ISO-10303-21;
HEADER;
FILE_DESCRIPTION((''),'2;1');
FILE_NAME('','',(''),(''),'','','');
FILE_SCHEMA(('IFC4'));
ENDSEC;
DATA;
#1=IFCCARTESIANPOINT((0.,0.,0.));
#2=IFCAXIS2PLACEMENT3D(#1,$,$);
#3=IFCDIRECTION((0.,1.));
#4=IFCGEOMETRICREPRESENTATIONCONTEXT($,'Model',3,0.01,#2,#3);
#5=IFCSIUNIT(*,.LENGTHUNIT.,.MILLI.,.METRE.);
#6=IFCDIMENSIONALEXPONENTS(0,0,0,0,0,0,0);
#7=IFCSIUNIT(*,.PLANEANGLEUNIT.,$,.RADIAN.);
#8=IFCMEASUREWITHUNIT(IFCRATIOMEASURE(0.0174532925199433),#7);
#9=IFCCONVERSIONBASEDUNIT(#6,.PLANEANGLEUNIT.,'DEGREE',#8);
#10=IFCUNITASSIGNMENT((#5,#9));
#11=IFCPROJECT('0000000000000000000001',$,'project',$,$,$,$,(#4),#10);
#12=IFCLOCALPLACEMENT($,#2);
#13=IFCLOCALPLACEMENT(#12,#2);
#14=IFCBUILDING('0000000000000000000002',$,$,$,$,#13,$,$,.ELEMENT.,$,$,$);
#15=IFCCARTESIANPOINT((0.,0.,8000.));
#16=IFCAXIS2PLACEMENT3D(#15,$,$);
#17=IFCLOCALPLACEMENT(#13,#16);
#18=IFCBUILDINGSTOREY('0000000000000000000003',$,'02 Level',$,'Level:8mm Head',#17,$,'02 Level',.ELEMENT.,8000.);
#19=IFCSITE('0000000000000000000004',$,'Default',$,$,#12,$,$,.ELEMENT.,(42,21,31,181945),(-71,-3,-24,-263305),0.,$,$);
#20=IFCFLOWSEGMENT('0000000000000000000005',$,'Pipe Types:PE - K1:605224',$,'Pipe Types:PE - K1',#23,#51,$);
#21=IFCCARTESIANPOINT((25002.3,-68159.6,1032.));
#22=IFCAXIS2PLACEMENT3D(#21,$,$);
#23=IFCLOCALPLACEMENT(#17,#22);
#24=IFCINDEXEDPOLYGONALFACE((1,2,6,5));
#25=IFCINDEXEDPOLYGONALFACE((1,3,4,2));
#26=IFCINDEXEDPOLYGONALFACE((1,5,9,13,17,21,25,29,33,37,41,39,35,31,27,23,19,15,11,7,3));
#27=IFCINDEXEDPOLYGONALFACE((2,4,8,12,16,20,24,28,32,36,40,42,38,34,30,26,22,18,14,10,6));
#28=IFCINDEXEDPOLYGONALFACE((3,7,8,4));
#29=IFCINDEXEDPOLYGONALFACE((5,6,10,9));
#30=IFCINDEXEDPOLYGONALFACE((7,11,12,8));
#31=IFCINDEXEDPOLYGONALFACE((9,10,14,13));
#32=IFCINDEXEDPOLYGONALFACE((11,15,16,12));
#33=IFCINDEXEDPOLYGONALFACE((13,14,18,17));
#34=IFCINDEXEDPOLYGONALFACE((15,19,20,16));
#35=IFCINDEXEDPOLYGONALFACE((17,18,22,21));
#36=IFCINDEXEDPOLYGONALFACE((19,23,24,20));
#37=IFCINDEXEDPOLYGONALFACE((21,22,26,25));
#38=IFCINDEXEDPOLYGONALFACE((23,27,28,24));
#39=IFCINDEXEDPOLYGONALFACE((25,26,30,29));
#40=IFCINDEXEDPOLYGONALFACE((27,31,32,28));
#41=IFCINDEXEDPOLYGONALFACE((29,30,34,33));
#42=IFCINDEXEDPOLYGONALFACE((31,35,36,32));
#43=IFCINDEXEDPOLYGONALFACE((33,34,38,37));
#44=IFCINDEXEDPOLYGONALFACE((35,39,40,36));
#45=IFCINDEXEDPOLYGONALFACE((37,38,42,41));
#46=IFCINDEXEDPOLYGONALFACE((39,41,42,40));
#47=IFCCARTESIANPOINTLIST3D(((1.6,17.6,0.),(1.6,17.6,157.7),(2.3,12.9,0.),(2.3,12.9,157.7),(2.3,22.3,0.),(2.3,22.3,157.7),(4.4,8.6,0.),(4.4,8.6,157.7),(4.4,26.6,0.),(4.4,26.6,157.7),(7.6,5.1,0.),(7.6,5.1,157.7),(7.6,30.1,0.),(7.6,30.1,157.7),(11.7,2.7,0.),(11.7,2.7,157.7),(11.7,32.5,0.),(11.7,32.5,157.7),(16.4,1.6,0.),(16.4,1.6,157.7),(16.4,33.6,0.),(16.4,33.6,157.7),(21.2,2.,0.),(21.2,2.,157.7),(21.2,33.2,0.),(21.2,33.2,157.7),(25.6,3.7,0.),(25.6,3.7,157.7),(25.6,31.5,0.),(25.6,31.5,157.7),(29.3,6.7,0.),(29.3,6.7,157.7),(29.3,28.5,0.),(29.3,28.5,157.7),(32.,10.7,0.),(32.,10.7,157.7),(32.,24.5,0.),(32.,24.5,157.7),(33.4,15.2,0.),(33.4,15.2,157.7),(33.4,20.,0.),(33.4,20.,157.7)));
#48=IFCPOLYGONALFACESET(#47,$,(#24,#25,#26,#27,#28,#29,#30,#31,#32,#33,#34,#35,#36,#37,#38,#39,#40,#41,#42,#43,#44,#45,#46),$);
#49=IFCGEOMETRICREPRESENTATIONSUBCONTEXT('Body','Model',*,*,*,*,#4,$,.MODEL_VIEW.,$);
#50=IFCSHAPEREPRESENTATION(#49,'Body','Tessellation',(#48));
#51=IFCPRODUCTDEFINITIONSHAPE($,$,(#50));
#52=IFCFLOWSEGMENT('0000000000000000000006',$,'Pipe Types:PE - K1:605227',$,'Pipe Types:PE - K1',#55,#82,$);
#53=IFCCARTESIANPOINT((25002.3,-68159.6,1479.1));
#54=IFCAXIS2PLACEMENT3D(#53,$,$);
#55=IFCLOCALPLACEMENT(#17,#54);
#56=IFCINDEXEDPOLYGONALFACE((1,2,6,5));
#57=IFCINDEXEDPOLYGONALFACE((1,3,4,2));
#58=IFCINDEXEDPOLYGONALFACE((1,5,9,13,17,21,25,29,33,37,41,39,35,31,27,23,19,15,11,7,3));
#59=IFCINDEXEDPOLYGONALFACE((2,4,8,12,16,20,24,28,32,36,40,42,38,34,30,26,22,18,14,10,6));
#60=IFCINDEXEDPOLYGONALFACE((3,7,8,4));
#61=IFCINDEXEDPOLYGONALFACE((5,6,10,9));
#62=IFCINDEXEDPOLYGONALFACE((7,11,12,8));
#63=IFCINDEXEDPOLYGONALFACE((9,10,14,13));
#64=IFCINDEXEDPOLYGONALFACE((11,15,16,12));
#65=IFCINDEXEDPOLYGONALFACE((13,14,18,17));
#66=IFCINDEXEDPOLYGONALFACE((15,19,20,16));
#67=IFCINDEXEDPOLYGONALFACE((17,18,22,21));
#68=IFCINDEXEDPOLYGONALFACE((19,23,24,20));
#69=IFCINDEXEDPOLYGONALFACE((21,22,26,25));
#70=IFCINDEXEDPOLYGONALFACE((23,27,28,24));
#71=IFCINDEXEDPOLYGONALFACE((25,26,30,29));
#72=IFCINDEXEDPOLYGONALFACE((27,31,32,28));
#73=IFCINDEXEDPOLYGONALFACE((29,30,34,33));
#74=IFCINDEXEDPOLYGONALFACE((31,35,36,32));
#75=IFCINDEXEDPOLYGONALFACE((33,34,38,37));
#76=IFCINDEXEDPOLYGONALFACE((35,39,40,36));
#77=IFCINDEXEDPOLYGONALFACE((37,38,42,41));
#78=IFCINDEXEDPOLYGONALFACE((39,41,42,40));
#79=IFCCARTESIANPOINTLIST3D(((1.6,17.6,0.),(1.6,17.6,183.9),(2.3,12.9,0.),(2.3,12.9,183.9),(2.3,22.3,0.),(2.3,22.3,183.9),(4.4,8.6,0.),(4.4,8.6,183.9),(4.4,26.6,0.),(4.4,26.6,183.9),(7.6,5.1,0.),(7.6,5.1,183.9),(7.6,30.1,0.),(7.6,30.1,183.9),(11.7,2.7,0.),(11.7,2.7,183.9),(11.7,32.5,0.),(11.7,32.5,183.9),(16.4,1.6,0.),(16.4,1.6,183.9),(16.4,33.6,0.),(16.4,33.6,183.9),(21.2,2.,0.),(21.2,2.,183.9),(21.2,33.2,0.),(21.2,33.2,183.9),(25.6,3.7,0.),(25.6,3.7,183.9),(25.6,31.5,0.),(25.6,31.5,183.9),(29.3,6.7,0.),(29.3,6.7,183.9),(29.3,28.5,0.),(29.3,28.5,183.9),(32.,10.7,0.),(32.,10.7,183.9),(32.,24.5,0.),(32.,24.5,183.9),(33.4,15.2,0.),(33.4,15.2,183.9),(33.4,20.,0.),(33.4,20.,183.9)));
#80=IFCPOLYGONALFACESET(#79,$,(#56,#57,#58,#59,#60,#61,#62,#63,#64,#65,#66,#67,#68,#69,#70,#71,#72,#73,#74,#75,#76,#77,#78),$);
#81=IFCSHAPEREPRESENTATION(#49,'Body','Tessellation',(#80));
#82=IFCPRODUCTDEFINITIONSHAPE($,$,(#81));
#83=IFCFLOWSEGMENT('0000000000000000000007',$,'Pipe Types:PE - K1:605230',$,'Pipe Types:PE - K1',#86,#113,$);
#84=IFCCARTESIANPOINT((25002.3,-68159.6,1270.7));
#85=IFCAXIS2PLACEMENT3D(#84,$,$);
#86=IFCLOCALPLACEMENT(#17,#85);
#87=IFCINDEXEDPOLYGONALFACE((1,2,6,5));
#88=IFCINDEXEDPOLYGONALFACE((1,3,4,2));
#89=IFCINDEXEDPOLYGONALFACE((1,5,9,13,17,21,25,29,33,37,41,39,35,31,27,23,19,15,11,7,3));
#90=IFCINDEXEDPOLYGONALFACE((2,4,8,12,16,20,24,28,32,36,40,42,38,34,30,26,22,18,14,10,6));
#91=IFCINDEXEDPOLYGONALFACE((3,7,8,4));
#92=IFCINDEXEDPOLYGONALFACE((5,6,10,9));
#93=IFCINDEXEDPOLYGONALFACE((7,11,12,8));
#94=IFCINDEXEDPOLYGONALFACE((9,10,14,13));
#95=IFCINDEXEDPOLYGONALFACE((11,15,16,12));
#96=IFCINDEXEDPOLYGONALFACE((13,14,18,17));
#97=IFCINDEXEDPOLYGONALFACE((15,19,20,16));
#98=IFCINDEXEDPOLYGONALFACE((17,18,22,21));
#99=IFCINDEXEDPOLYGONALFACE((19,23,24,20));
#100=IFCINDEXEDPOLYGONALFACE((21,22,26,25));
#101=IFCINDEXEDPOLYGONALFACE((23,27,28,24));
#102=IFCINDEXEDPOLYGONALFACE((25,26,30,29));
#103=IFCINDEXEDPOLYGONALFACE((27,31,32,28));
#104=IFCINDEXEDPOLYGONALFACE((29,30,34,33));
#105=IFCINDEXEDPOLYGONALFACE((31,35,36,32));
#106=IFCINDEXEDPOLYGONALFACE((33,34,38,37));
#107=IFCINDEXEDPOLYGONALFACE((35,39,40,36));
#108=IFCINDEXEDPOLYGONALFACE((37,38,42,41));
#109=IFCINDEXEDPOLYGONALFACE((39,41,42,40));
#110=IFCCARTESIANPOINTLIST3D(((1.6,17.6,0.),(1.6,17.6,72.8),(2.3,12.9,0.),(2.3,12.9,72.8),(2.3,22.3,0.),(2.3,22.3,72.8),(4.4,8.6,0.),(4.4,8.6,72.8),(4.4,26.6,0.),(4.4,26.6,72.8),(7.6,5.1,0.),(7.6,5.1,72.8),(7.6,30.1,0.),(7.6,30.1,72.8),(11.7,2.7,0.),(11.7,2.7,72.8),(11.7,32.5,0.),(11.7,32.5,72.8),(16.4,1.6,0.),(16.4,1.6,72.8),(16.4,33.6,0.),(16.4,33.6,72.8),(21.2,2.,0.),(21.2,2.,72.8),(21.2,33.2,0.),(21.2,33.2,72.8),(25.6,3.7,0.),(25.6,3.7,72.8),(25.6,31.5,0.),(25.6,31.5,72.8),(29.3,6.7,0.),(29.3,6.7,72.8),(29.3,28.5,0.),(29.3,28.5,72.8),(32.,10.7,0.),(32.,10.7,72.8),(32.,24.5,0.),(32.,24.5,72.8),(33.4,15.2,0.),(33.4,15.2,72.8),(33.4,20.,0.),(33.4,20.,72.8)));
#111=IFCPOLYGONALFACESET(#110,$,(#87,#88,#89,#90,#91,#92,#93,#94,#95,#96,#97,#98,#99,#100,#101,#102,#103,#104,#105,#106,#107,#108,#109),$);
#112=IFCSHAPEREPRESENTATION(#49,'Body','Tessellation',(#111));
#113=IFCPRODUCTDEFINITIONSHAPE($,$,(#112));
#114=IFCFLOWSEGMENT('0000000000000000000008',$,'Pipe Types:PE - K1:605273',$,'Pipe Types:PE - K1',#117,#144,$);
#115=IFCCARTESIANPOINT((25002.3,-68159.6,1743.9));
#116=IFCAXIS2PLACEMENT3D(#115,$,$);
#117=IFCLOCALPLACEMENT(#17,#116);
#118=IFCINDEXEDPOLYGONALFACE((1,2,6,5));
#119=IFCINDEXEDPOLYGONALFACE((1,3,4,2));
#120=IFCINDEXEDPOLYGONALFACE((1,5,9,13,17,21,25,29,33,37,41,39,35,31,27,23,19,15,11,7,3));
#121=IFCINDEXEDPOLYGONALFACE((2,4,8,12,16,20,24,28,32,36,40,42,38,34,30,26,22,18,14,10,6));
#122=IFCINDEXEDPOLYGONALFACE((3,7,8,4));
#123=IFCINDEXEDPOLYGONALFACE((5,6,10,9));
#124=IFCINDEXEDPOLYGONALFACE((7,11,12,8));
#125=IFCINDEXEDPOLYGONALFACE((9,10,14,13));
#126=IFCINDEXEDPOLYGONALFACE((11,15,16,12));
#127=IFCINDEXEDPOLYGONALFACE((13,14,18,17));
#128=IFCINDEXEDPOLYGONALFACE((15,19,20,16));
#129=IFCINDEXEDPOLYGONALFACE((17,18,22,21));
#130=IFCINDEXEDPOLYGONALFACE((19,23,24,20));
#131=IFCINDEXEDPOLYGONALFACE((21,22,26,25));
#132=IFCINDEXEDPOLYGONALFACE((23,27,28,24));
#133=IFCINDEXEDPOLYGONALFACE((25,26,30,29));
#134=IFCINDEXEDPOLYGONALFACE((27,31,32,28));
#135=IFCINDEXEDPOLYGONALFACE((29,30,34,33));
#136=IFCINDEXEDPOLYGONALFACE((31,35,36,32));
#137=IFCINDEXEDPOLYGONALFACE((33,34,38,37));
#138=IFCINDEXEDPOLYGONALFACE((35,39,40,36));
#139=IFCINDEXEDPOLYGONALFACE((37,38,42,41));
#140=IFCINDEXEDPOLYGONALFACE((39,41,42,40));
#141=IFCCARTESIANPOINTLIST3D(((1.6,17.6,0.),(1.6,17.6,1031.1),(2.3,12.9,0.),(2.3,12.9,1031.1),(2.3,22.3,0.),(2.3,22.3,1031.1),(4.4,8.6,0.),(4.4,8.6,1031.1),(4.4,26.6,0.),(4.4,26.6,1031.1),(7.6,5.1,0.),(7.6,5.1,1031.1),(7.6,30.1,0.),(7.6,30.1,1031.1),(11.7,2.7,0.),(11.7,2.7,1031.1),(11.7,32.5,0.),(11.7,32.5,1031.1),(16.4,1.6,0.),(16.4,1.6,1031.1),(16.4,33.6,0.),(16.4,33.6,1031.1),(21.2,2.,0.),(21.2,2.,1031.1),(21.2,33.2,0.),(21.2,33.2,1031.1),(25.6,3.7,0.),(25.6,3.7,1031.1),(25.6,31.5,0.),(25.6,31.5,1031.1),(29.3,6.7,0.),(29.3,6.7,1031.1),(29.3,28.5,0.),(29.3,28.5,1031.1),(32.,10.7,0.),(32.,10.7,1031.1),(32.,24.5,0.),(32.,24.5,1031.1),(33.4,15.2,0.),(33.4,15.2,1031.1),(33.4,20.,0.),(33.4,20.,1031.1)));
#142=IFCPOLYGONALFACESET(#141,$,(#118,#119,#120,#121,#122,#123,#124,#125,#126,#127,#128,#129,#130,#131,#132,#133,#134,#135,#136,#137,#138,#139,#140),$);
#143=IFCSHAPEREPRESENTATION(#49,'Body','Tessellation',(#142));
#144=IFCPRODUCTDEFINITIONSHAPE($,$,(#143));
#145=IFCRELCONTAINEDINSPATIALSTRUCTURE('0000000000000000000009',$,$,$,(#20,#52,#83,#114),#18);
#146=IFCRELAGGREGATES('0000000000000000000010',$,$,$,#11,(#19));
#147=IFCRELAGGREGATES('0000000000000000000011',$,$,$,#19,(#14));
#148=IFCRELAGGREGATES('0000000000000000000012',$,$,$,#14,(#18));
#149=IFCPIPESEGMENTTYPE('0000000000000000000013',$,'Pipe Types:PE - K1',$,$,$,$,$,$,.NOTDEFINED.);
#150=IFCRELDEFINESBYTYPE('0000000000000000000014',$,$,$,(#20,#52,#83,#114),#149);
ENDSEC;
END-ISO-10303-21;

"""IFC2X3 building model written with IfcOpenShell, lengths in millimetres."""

from ifc_helpers import new_model, entity, si_unit, converted_unit, direction, frame, origin, origin_2d_with_axis, place, context, subcontext, project, spatial, circle, extrude, type_object, element, save


model = new_model("IFC2X3")

# Units and contexts
model_context = context("Model", 3, precision=0.01, world=origin(), true_north=direction((0.0, 1.0)))
body_context = subcontext(model_context, "Body", "Model", "MODEL_VIEW")
ifc_project = project(units=[si_unit("LENGTHUNIT", "METRE", prefix="MILLI"), converted_unit("PLANEANGLEUNIT", "DEGREE", entity("IfcRatioMeasure", 0.0174532925199433), si_unit("PLANEANGLEUNIT", "RADIAN"), dimensions=[0, 0, 0, 0, 0, 0, 0])], contexts=[model_context])

# Site, building, storey
site_placement = place(None, origin())
site = spatial("IfcSite", under=ifc_project, at=site_placement, Name="Default", CompositionType="ELEMENT", RefLatitude=(42, 21, 31, 181945), RefLongitude=(-71, -3, -24, -263305), RefElevation=0.0)
building_placement = place(site_placement, origin())
building = spatial("IfcBuilding", under=site, at=building_placement, CompositionType="ELEMENT")
storey_placement = place(building_placement, frame((0.0, 0.0, 8000.0)))
storey = spatial("IfcBuildingStorey", under=building, at=storey_placement, Name="02 Level", ObjectType="Level:8mm Head", LongName="02 Level", CompositionType="ELEMENT", Elevation=8000.0)

# Flow segments
pipe_segment_type = type_object("IfcPipeSegmentType", Name="Pipe Types:PE - K1", PredefinedType="NOTDEFINED")
flow_segment_1_placement = place(storey_placement, frame((25002.3, -68159.6, 1032.0)))
element("IfcFlowSegment", 1, at=flow_segment_1_placement, inside=storey, type_object=pipe_segment_type, Name="Pipe Types:PE - K1:605224", ObjectType="Pipe Types:PE - K1", context=body_context, shape_type="SweptSolid", body=[
    extrude(circle(Radius=16.0, at=origin_2d_with_axis()), frame((17.6, 17.6, 0.0), z_axis=(0.0, 0.0, 1.0), x_axis=(-1.0, 0.0, 0.0)), (0.0, 0.0, 1.0), 157.7),
])
flow_segment_2_placement = place(storey_placement, frame((25002.3, -68159.6, 1479.1)))
element("IfcFlowSegment", 2, at=flow_segment_2_placement, inside=storey, type_object=pipe_segment_type, Name="Pipe Types:PE - K1:605227", ObjectType="Pipe Types:PE - K1", context=body_context, shape_type="SweptSolid", body=[
    extrude(circle(Radius=16.0, at=origin_2d_with_axis()), frame((17.6, 17.6, 0.0), z_axis=(0.0, 0.0, 1.0), x_axis=(-1.0, 0.0, 0.0)), (0.0, 0.0, 1.0), 183.9),
])
flow_segment_3_placement = place(storey_placement, frame((25002.3, -68159.6, 1270.7)))
element("IfcFlowSegment", 3, at=flow_segment_3_placement, inside=storey, type_object=pipe_segment_type, Name="Pipe Types:PE - K1:605230", ObjectType="Pipe Types:PE - K1", context=body_context, shape_type="SweptSolid", body=[
    extrude(circle(Radius=16.0, at=origin_2d_with_axis()), frame((17.6, 17.6, 0.0), z_axis=(0.0, 0.0, 1.0), x_axis=(-1.0, 0.0, 0.0)), (0.0, 0.0, 1.0), 72.8),
])
flow_segment_4_placement = place(storey_placement, frame((25002.3, -68159.6, 1743.9)))
element("IfcFlowSegment", 4, at=flow_segment_4_placement, inside=storey, type_object=pipe_segment_type, Name="Pipe Types:PE - K1:605273", ObjectType="Pipe Types:PE - K1", context=body_context, shape_type="SweptSolid", body=[
    extrude(circle(Radius=16.0, at=origin_2d_with_axis()), frame((17.6, 17.6, 0.0), z_axis=(0.0, 0.0, 1.0), x_axis=(-1.0, 0.0, 0.0)), (0.0, 0.0, 1.0), 1031.1),
])

save(model, "model.ifc")
